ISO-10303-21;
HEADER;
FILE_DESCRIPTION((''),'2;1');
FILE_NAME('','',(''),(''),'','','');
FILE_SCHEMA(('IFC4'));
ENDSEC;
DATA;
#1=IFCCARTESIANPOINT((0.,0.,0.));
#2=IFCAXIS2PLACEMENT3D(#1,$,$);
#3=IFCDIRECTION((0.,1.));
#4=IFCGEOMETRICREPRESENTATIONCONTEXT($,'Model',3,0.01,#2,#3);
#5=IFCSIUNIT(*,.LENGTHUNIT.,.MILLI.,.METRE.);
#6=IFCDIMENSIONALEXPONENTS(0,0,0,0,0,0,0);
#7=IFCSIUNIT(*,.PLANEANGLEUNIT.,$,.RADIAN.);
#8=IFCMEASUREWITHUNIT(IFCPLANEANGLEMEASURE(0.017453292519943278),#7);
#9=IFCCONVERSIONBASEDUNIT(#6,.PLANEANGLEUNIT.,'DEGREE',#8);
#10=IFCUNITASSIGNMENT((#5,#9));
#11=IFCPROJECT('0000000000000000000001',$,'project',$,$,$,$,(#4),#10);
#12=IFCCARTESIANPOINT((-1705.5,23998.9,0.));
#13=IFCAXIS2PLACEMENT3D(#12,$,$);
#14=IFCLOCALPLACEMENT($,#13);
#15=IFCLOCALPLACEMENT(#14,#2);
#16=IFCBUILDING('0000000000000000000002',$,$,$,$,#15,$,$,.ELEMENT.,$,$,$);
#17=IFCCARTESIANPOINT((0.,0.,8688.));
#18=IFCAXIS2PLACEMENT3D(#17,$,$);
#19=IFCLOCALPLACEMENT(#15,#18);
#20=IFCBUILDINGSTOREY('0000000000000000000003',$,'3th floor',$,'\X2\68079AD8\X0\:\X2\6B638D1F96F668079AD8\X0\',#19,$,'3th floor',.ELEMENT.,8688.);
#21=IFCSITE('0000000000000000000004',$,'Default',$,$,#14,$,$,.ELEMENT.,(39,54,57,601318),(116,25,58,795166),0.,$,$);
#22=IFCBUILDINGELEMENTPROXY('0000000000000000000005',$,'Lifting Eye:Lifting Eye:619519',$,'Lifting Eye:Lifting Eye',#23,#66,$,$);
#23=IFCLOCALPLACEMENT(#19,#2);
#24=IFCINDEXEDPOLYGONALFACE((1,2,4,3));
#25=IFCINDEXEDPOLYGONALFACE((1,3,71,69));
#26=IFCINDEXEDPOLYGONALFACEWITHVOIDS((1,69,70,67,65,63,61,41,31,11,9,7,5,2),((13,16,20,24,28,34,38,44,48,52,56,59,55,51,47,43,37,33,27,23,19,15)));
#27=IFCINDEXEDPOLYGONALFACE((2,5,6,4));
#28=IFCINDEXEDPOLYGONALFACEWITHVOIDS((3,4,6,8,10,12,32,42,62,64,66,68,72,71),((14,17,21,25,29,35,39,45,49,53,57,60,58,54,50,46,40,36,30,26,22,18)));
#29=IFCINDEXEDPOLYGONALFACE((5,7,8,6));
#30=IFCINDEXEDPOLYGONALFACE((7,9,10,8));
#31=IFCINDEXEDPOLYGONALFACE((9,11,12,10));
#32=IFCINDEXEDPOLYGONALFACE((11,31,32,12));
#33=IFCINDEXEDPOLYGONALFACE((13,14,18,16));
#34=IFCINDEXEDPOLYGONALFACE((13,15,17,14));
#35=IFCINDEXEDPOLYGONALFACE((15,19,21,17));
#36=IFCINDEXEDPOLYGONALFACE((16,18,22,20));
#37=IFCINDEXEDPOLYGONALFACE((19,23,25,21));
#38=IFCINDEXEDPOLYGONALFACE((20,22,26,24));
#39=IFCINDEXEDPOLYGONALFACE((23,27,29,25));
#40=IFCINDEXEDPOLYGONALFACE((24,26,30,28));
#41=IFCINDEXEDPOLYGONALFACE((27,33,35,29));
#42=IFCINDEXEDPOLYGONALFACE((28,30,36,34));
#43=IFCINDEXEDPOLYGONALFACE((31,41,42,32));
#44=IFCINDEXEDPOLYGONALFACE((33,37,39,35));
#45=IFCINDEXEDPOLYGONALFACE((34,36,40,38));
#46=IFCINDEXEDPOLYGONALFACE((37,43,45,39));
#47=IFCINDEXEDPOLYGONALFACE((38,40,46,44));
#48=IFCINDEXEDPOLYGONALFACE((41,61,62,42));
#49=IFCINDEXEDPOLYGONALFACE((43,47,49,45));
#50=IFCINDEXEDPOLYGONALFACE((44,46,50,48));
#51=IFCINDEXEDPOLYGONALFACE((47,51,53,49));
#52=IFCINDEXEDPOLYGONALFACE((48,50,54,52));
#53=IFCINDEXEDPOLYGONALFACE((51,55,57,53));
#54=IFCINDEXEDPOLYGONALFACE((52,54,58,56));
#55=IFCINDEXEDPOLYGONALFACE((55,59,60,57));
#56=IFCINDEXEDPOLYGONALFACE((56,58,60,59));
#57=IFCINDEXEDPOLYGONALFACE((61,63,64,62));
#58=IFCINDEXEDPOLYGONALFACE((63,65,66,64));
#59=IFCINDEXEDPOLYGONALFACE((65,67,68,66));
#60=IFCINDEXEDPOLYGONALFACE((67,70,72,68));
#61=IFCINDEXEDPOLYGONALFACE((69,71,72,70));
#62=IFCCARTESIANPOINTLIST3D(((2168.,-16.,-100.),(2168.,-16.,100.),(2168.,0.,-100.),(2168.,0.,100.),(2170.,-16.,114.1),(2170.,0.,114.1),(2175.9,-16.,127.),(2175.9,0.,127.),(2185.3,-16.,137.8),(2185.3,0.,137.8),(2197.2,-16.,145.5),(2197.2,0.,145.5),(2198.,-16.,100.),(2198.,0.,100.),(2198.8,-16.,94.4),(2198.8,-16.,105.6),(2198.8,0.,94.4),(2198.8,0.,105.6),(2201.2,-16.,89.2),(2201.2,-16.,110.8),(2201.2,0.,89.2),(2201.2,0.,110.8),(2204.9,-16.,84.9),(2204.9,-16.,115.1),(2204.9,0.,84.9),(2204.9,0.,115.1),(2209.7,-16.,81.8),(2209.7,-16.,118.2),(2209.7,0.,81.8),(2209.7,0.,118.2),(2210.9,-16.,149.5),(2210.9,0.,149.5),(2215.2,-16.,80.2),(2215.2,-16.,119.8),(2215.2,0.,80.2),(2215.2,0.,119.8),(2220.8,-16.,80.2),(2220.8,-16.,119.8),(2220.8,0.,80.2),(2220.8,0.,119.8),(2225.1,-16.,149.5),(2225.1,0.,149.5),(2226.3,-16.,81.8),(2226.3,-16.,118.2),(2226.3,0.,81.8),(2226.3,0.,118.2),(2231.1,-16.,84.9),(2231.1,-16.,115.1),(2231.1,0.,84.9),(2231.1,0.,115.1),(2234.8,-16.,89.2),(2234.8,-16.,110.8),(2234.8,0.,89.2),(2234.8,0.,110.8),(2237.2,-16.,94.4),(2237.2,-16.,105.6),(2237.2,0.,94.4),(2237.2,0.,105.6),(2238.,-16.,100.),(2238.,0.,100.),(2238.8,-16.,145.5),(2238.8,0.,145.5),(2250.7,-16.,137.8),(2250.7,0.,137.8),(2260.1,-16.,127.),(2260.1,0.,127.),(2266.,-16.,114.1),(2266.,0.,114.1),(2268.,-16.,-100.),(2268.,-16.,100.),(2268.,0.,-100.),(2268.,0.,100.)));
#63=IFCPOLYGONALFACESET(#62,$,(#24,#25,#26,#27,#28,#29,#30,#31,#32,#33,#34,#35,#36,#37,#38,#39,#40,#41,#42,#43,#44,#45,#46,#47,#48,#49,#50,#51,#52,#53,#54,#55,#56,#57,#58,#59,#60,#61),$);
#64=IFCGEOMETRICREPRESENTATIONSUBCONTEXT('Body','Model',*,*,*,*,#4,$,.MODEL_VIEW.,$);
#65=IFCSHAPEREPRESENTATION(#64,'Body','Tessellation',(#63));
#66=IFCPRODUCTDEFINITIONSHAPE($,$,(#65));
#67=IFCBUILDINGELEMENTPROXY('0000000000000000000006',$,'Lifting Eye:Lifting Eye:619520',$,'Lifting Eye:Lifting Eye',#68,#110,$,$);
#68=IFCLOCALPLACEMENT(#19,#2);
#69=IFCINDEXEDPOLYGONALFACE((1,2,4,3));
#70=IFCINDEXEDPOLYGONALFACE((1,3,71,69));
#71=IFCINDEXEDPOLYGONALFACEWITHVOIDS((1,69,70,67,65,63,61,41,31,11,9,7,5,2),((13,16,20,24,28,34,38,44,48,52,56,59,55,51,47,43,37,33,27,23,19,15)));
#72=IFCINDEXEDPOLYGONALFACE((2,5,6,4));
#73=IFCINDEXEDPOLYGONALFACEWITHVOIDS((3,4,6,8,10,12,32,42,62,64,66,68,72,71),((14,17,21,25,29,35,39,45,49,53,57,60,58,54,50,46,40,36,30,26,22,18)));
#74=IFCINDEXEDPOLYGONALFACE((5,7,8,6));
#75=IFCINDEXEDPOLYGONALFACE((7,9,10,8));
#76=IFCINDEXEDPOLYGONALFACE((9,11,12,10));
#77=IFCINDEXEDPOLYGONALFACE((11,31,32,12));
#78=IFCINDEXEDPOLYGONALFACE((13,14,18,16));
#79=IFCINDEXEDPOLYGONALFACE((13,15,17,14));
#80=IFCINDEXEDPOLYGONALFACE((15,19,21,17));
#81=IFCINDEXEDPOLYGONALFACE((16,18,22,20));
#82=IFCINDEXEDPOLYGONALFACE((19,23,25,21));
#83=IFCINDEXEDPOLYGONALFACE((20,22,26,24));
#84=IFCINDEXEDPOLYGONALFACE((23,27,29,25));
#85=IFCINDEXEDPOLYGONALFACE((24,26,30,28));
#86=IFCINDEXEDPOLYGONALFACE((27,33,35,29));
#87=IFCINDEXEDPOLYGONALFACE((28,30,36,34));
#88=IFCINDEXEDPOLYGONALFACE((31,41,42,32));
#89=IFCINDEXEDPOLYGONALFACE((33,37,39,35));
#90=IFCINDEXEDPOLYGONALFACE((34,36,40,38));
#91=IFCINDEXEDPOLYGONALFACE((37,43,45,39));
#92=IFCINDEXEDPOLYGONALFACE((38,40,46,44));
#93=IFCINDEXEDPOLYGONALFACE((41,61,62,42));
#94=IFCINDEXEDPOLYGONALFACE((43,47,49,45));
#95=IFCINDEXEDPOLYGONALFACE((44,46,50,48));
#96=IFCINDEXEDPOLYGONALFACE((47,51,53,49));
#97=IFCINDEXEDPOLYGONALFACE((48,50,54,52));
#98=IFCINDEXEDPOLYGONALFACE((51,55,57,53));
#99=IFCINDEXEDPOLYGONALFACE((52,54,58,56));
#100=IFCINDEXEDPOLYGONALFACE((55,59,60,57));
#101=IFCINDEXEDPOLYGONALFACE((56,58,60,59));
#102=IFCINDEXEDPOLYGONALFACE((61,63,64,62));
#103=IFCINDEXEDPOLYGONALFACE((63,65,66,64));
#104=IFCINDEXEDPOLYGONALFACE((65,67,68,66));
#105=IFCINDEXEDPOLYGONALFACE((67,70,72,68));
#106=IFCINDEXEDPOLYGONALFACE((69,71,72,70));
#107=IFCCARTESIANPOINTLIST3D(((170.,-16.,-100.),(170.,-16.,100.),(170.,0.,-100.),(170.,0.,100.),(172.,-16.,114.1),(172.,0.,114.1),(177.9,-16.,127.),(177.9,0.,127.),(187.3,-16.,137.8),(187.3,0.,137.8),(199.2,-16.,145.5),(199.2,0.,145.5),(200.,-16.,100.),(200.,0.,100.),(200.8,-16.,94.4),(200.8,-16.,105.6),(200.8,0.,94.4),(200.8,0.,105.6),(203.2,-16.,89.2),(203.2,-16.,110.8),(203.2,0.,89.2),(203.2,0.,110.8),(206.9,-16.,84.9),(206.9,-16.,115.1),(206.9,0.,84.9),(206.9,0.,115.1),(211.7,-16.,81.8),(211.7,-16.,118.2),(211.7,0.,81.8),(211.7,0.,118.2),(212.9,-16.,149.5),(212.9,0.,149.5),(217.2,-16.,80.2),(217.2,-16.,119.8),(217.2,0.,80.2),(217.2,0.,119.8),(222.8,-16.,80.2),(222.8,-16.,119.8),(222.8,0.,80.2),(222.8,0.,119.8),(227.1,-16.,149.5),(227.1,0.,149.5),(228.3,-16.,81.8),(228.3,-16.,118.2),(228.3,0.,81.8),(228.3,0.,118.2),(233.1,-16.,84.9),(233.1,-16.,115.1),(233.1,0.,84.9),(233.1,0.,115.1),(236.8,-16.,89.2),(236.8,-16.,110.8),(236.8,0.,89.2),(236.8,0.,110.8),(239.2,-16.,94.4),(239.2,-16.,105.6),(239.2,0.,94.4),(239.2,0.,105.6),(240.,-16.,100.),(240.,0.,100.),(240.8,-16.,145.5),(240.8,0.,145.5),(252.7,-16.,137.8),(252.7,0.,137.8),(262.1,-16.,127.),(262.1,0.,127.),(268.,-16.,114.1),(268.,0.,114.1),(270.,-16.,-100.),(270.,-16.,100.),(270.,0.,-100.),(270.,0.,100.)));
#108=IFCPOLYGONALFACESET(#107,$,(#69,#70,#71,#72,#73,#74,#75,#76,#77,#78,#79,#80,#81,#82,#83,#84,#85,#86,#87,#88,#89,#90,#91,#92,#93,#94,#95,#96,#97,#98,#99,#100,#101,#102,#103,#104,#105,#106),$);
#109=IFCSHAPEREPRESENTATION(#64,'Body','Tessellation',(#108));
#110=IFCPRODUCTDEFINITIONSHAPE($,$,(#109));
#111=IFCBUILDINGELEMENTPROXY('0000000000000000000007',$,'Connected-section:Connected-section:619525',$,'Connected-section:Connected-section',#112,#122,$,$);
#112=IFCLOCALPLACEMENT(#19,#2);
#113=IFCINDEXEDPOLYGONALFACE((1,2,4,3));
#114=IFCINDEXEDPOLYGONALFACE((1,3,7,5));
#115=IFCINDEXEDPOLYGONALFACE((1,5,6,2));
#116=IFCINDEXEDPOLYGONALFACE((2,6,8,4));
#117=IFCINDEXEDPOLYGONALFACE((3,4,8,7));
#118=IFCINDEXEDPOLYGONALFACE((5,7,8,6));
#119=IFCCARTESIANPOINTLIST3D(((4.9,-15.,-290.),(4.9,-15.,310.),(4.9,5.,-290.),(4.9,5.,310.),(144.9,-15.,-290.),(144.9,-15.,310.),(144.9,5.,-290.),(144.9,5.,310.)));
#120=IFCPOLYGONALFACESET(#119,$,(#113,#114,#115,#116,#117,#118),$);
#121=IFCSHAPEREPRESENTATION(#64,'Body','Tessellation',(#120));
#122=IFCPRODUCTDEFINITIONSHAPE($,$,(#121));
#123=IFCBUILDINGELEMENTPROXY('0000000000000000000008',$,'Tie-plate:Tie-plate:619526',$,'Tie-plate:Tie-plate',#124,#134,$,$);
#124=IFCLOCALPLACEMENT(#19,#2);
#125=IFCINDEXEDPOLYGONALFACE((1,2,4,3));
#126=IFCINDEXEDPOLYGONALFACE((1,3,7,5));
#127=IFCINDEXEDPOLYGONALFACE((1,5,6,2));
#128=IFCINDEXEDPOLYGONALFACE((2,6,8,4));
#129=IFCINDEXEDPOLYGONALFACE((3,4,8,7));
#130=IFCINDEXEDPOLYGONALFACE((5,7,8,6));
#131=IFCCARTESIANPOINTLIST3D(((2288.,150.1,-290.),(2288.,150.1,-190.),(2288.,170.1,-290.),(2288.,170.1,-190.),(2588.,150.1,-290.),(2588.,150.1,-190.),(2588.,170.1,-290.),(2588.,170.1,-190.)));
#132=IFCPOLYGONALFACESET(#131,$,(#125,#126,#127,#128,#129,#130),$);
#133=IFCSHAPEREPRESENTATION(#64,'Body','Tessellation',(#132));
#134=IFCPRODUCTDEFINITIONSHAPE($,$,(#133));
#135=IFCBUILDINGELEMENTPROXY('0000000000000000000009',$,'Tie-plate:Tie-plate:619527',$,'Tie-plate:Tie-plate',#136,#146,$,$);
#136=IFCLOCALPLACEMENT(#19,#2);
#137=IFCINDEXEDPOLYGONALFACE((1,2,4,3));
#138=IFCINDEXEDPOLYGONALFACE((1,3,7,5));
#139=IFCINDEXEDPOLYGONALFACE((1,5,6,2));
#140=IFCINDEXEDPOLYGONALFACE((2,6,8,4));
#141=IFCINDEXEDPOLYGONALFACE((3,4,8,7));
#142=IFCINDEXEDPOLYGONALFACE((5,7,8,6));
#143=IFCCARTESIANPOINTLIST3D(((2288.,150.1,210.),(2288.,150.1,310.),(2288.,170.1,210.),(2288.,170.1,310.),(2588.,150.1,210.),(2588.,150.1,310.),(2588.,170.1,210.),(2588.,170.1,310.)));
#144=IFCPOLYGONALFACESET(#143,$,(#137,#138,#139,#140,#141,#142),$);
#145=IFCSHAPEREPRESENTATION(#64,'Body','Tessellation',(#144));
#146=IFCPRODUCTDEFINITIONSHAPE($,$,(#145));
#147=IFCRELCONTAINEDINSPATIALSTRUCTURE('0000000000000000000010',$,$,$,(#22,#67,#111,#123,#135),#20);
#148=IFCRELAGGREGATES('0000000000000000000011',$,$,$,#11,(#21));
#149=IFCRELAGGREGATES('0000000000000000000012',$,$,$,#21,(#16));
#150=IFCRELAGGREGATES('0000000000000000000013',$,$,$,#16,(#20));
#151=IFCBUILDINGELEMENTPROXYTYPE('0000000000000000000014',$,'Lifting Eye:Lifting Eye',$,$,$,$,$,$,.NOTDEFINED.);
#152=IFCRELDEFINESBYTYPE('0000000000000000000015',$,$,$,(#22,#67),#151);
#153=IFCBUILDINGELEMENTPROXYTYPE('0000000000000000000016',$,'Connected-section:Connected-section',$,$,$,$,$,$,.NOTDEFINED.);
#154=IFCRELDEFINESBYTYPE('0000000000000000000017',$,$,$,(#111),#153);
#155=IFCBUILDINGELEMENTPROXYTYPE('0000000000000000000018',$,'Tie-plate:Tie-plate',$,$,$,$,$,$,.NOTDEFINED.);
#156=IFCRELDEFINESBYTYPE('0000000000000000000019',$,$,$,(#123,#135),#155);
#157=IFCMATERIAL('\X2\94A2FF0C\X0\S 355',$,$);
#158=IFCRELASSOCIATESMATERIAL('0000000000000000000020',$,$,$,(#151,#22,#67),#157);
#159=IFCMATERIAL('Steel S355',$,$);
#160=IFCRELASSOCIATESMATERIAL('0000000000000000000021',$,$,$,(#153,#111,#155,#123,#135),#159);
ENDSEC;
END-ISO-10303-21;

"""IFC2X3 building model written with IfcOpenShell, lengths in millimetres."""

from ifc_helpers import new_model, entity, si_unit, converted_unit, direction, frame, frame_2d, origin, place, context, subcontext, project, spatial, polyline, circle_curve, parameter, trimmed, segment, composite_curve, rectangle, outline, extrude, source, transform, mapped, material, type_object, type_shapes, element, save


model = new_model("IFC2X3")

# Units and contexts
model_context = context("Model", 3, precision=0.01, world=origin(), true_north=direction((0.0, 1.0)))
body_context = subcontext(model_context, "Body", "Model", "MODEL_VIEW")
ifc_project = project(units=[si_unit("LENGTHUNIT", "METRE", prefix="MILLI"), converted_unit("PLANEANGLEUNIT", "DEGREE", entity("IfcPlaneAngleMeasure", 0.017453292519943278), si_unit("PLANEANGLEUNIT", "RADIAN"), dimensions=[0, 0, 0, 0, 0, 0, 0])], contexts=[model_context])

# Site, building, storey
site_placement = place(None, frame((-1705.5, 23998.9, 0.0)))
site = spatial("IfcSite", under=ifc_project, at=site_placement, Name="Default", CompositionType="ELEMENT", RefLatitude=(39, 54, 57, 601318), RefLongitude=(116, 25, 58, 795166), RefElevation=0.0)
building_placement = place(site_placement, origin())
building = spatial("IfcBuilding", under=site, at=building_placement, CompositionType="ELEMENT")
storey_placement = place(building_placement, frame((0.0, 0.0, 8688.0)))
storey = spatial("IfcBuildingStorey", under=building, at=storey_placement, Name="3th floor", ObjectType="标高:正负零标高", LongName="3th floor", CompositionType="ELEMENT", Elevation=8688.0)

# Shared definitions
ifc_material_1 = material(Name="Steel S355")

# Building element proxies
ifc_material_2 = material(Name="钢，S 355")
building_element_proxy_type_1 = type_object("IfcBuildingElementProxyType", Name="Lifting Eye:Lifting Eye", PredefinedType="NOTDEFINED", material=ifc_material_2)
shared_shape_1 = source(origin(), body_context, "Body", "SweptSolid", [
    extrude(outline(composite_curve([segment(polyline([(-100.0, -50.0), (100.0, -50.0)]), True, "CONTINUOUS"), segment(polyline([(100.0, -50.0), (100.0, 50.0)]), True, "CONTINUOUS"), segment(polyline([(100.0, 50.0), (-100.0, 50.0)]), True, "CONTINUOUS"), segment(trimmed(circle_curve(frame_2d((-100.0, 0.0), x_axis=(0.0, -1.0)), 50.0), [parameter(180.0)], [parameter(0.0)], True, "PARAMETER"), True, "CONTINUOUS")], self_intersect=False), holes=[composite_curve([segment(trimmed(circle_curve(frame_2d((-100.0, 0.0), x_axis=(0.0, -1.0)), 20.0), [parameter(180.0)], [parameter(360.0)], True, "PARAMETER"), False, "CONTINUOUS"), segment(trimmed(circle_curve(frame_2d((-100.0, 0.0), x_axis=(0.0, -1.0)), 20.0), [parameter(0.0)], [parameter(180.0)], True, "PARAMETER"), False, "CONTINUOUS")], self_intersect=False)]), frame((0.0, 17.0, -17.0), z_axis=(0.0, 1.0, 0.0), x_axis=(0.0, 0.0, -1.0)), (0.0, 0.0, 1.0), 16.0),
])
type_shapes(building_element_proxy_type_1, [shared_shape_1])
for number, where, name in (
    (1, (2218.0, -33.0, 17.0), "Lifting Eye:Lifting Eye:619519"),
    (2, (220.0, -33.0, 17.0), "Lifting Eye:Lifting Eye:619520"),
):
    element("IfcBuildingElementProxy", number, at=place(storey_placement, frame(where)), inside=storey, type_object=building_element_proxy_type_1, material=ifc_material_2, Name=name, ObjectType="Lifting Eye:Lifting Eye", context=body_context, shape_type="MappedRepresentation", body=[
        mapped(shared_shape_1, transform((0.0, 0.0, 0.0), scale=1.0)),
    ])
building_element_proxy_type_2 = type_object("IfcBuildingElementProxyType", Name="Connected-section:Connected-section", PredefinedType="NOTDEFINED", material=ifc_material_1)
shared_shape_2 = source(origin(), body_context, "Body", "SweptSolid", [
    extrude(rectangle(XDim=20.0, YDim=140.0, at=frame_2d((0.0, 0.0), x_axis=(1.0, 0.0))), frame((70.0, 10.0, 0.0), z_axis=(0.0, 0.0, 1.0), x_axis=(0.0, 1.0, 0.0)), (0.0, 0.0, 1.0), 600.0),
])
type_shapes(building_element_proxy_type_2, [shared_shape_2])
proxy_1_placement = place(storey_placement, frame((4.9, -15.0, -290.0)))
element("IfcBuildingElementProxy", 3, at=proxy_1_placement, inside=storey, type_object=building_element_proxy_type_2, material=ifc_material_1, Name="Connected-section:Connected-section:619525", ObjectType="Connected-section:Connected-section", context=body_context, shape_type="MappedRepresentation", body=[
    mapped(shared_shape_2, transform((0.0, 0.0, 0.0), scale=1.0)),
])
building_element_proxy_type_3 = type_object("IfcBuildingElementProxyType", Name="Tie-plate:Tie-plate", PredefinedType="NOTDEFINED", material=ifc_material_1)
shared_shape_3 = source(origin(), body_context, "Body", "SweptSolid", [
    extrude(rectangle(XDim=20.0, YDim=300.0, at=frame_2d((0.0, 0.0), x_axis=(1.0, 0.0))), frame((150.0, 10.0, 0.0), z_axis=(0.0, 0.0, 1.0), x_axis=(0.0, 1.0, 0.0)), (0.0, 0.0, 1.0), 100.0),
])
type_shapes(building_element_proxy_type_3, [shared_shape_3])
for number, where, name in (
    (4, (2288.0, 150.1, -290.0), "Tie-plate:Tie-plate:619526"),
    (5, (2288.0, 150.1, 210.0), "Tie-plate:Tie-plate:619527"),
):
    element("IfcBuildingElementProxy", number, at=place(storey_placement, frame(where)), inside=storey, type_object=building_element_proxy_type_3, material=ifc_material_1, Name=name, ObjectType="Tie-plate:Tie-plate", context=body_context, shape_type="MappedRepresentation", body=[
        mapped(shared_shape_3, transform((0.0, 0.0, 0.0), scale=1.0)),
    ])

save(model, "model.ifc")
